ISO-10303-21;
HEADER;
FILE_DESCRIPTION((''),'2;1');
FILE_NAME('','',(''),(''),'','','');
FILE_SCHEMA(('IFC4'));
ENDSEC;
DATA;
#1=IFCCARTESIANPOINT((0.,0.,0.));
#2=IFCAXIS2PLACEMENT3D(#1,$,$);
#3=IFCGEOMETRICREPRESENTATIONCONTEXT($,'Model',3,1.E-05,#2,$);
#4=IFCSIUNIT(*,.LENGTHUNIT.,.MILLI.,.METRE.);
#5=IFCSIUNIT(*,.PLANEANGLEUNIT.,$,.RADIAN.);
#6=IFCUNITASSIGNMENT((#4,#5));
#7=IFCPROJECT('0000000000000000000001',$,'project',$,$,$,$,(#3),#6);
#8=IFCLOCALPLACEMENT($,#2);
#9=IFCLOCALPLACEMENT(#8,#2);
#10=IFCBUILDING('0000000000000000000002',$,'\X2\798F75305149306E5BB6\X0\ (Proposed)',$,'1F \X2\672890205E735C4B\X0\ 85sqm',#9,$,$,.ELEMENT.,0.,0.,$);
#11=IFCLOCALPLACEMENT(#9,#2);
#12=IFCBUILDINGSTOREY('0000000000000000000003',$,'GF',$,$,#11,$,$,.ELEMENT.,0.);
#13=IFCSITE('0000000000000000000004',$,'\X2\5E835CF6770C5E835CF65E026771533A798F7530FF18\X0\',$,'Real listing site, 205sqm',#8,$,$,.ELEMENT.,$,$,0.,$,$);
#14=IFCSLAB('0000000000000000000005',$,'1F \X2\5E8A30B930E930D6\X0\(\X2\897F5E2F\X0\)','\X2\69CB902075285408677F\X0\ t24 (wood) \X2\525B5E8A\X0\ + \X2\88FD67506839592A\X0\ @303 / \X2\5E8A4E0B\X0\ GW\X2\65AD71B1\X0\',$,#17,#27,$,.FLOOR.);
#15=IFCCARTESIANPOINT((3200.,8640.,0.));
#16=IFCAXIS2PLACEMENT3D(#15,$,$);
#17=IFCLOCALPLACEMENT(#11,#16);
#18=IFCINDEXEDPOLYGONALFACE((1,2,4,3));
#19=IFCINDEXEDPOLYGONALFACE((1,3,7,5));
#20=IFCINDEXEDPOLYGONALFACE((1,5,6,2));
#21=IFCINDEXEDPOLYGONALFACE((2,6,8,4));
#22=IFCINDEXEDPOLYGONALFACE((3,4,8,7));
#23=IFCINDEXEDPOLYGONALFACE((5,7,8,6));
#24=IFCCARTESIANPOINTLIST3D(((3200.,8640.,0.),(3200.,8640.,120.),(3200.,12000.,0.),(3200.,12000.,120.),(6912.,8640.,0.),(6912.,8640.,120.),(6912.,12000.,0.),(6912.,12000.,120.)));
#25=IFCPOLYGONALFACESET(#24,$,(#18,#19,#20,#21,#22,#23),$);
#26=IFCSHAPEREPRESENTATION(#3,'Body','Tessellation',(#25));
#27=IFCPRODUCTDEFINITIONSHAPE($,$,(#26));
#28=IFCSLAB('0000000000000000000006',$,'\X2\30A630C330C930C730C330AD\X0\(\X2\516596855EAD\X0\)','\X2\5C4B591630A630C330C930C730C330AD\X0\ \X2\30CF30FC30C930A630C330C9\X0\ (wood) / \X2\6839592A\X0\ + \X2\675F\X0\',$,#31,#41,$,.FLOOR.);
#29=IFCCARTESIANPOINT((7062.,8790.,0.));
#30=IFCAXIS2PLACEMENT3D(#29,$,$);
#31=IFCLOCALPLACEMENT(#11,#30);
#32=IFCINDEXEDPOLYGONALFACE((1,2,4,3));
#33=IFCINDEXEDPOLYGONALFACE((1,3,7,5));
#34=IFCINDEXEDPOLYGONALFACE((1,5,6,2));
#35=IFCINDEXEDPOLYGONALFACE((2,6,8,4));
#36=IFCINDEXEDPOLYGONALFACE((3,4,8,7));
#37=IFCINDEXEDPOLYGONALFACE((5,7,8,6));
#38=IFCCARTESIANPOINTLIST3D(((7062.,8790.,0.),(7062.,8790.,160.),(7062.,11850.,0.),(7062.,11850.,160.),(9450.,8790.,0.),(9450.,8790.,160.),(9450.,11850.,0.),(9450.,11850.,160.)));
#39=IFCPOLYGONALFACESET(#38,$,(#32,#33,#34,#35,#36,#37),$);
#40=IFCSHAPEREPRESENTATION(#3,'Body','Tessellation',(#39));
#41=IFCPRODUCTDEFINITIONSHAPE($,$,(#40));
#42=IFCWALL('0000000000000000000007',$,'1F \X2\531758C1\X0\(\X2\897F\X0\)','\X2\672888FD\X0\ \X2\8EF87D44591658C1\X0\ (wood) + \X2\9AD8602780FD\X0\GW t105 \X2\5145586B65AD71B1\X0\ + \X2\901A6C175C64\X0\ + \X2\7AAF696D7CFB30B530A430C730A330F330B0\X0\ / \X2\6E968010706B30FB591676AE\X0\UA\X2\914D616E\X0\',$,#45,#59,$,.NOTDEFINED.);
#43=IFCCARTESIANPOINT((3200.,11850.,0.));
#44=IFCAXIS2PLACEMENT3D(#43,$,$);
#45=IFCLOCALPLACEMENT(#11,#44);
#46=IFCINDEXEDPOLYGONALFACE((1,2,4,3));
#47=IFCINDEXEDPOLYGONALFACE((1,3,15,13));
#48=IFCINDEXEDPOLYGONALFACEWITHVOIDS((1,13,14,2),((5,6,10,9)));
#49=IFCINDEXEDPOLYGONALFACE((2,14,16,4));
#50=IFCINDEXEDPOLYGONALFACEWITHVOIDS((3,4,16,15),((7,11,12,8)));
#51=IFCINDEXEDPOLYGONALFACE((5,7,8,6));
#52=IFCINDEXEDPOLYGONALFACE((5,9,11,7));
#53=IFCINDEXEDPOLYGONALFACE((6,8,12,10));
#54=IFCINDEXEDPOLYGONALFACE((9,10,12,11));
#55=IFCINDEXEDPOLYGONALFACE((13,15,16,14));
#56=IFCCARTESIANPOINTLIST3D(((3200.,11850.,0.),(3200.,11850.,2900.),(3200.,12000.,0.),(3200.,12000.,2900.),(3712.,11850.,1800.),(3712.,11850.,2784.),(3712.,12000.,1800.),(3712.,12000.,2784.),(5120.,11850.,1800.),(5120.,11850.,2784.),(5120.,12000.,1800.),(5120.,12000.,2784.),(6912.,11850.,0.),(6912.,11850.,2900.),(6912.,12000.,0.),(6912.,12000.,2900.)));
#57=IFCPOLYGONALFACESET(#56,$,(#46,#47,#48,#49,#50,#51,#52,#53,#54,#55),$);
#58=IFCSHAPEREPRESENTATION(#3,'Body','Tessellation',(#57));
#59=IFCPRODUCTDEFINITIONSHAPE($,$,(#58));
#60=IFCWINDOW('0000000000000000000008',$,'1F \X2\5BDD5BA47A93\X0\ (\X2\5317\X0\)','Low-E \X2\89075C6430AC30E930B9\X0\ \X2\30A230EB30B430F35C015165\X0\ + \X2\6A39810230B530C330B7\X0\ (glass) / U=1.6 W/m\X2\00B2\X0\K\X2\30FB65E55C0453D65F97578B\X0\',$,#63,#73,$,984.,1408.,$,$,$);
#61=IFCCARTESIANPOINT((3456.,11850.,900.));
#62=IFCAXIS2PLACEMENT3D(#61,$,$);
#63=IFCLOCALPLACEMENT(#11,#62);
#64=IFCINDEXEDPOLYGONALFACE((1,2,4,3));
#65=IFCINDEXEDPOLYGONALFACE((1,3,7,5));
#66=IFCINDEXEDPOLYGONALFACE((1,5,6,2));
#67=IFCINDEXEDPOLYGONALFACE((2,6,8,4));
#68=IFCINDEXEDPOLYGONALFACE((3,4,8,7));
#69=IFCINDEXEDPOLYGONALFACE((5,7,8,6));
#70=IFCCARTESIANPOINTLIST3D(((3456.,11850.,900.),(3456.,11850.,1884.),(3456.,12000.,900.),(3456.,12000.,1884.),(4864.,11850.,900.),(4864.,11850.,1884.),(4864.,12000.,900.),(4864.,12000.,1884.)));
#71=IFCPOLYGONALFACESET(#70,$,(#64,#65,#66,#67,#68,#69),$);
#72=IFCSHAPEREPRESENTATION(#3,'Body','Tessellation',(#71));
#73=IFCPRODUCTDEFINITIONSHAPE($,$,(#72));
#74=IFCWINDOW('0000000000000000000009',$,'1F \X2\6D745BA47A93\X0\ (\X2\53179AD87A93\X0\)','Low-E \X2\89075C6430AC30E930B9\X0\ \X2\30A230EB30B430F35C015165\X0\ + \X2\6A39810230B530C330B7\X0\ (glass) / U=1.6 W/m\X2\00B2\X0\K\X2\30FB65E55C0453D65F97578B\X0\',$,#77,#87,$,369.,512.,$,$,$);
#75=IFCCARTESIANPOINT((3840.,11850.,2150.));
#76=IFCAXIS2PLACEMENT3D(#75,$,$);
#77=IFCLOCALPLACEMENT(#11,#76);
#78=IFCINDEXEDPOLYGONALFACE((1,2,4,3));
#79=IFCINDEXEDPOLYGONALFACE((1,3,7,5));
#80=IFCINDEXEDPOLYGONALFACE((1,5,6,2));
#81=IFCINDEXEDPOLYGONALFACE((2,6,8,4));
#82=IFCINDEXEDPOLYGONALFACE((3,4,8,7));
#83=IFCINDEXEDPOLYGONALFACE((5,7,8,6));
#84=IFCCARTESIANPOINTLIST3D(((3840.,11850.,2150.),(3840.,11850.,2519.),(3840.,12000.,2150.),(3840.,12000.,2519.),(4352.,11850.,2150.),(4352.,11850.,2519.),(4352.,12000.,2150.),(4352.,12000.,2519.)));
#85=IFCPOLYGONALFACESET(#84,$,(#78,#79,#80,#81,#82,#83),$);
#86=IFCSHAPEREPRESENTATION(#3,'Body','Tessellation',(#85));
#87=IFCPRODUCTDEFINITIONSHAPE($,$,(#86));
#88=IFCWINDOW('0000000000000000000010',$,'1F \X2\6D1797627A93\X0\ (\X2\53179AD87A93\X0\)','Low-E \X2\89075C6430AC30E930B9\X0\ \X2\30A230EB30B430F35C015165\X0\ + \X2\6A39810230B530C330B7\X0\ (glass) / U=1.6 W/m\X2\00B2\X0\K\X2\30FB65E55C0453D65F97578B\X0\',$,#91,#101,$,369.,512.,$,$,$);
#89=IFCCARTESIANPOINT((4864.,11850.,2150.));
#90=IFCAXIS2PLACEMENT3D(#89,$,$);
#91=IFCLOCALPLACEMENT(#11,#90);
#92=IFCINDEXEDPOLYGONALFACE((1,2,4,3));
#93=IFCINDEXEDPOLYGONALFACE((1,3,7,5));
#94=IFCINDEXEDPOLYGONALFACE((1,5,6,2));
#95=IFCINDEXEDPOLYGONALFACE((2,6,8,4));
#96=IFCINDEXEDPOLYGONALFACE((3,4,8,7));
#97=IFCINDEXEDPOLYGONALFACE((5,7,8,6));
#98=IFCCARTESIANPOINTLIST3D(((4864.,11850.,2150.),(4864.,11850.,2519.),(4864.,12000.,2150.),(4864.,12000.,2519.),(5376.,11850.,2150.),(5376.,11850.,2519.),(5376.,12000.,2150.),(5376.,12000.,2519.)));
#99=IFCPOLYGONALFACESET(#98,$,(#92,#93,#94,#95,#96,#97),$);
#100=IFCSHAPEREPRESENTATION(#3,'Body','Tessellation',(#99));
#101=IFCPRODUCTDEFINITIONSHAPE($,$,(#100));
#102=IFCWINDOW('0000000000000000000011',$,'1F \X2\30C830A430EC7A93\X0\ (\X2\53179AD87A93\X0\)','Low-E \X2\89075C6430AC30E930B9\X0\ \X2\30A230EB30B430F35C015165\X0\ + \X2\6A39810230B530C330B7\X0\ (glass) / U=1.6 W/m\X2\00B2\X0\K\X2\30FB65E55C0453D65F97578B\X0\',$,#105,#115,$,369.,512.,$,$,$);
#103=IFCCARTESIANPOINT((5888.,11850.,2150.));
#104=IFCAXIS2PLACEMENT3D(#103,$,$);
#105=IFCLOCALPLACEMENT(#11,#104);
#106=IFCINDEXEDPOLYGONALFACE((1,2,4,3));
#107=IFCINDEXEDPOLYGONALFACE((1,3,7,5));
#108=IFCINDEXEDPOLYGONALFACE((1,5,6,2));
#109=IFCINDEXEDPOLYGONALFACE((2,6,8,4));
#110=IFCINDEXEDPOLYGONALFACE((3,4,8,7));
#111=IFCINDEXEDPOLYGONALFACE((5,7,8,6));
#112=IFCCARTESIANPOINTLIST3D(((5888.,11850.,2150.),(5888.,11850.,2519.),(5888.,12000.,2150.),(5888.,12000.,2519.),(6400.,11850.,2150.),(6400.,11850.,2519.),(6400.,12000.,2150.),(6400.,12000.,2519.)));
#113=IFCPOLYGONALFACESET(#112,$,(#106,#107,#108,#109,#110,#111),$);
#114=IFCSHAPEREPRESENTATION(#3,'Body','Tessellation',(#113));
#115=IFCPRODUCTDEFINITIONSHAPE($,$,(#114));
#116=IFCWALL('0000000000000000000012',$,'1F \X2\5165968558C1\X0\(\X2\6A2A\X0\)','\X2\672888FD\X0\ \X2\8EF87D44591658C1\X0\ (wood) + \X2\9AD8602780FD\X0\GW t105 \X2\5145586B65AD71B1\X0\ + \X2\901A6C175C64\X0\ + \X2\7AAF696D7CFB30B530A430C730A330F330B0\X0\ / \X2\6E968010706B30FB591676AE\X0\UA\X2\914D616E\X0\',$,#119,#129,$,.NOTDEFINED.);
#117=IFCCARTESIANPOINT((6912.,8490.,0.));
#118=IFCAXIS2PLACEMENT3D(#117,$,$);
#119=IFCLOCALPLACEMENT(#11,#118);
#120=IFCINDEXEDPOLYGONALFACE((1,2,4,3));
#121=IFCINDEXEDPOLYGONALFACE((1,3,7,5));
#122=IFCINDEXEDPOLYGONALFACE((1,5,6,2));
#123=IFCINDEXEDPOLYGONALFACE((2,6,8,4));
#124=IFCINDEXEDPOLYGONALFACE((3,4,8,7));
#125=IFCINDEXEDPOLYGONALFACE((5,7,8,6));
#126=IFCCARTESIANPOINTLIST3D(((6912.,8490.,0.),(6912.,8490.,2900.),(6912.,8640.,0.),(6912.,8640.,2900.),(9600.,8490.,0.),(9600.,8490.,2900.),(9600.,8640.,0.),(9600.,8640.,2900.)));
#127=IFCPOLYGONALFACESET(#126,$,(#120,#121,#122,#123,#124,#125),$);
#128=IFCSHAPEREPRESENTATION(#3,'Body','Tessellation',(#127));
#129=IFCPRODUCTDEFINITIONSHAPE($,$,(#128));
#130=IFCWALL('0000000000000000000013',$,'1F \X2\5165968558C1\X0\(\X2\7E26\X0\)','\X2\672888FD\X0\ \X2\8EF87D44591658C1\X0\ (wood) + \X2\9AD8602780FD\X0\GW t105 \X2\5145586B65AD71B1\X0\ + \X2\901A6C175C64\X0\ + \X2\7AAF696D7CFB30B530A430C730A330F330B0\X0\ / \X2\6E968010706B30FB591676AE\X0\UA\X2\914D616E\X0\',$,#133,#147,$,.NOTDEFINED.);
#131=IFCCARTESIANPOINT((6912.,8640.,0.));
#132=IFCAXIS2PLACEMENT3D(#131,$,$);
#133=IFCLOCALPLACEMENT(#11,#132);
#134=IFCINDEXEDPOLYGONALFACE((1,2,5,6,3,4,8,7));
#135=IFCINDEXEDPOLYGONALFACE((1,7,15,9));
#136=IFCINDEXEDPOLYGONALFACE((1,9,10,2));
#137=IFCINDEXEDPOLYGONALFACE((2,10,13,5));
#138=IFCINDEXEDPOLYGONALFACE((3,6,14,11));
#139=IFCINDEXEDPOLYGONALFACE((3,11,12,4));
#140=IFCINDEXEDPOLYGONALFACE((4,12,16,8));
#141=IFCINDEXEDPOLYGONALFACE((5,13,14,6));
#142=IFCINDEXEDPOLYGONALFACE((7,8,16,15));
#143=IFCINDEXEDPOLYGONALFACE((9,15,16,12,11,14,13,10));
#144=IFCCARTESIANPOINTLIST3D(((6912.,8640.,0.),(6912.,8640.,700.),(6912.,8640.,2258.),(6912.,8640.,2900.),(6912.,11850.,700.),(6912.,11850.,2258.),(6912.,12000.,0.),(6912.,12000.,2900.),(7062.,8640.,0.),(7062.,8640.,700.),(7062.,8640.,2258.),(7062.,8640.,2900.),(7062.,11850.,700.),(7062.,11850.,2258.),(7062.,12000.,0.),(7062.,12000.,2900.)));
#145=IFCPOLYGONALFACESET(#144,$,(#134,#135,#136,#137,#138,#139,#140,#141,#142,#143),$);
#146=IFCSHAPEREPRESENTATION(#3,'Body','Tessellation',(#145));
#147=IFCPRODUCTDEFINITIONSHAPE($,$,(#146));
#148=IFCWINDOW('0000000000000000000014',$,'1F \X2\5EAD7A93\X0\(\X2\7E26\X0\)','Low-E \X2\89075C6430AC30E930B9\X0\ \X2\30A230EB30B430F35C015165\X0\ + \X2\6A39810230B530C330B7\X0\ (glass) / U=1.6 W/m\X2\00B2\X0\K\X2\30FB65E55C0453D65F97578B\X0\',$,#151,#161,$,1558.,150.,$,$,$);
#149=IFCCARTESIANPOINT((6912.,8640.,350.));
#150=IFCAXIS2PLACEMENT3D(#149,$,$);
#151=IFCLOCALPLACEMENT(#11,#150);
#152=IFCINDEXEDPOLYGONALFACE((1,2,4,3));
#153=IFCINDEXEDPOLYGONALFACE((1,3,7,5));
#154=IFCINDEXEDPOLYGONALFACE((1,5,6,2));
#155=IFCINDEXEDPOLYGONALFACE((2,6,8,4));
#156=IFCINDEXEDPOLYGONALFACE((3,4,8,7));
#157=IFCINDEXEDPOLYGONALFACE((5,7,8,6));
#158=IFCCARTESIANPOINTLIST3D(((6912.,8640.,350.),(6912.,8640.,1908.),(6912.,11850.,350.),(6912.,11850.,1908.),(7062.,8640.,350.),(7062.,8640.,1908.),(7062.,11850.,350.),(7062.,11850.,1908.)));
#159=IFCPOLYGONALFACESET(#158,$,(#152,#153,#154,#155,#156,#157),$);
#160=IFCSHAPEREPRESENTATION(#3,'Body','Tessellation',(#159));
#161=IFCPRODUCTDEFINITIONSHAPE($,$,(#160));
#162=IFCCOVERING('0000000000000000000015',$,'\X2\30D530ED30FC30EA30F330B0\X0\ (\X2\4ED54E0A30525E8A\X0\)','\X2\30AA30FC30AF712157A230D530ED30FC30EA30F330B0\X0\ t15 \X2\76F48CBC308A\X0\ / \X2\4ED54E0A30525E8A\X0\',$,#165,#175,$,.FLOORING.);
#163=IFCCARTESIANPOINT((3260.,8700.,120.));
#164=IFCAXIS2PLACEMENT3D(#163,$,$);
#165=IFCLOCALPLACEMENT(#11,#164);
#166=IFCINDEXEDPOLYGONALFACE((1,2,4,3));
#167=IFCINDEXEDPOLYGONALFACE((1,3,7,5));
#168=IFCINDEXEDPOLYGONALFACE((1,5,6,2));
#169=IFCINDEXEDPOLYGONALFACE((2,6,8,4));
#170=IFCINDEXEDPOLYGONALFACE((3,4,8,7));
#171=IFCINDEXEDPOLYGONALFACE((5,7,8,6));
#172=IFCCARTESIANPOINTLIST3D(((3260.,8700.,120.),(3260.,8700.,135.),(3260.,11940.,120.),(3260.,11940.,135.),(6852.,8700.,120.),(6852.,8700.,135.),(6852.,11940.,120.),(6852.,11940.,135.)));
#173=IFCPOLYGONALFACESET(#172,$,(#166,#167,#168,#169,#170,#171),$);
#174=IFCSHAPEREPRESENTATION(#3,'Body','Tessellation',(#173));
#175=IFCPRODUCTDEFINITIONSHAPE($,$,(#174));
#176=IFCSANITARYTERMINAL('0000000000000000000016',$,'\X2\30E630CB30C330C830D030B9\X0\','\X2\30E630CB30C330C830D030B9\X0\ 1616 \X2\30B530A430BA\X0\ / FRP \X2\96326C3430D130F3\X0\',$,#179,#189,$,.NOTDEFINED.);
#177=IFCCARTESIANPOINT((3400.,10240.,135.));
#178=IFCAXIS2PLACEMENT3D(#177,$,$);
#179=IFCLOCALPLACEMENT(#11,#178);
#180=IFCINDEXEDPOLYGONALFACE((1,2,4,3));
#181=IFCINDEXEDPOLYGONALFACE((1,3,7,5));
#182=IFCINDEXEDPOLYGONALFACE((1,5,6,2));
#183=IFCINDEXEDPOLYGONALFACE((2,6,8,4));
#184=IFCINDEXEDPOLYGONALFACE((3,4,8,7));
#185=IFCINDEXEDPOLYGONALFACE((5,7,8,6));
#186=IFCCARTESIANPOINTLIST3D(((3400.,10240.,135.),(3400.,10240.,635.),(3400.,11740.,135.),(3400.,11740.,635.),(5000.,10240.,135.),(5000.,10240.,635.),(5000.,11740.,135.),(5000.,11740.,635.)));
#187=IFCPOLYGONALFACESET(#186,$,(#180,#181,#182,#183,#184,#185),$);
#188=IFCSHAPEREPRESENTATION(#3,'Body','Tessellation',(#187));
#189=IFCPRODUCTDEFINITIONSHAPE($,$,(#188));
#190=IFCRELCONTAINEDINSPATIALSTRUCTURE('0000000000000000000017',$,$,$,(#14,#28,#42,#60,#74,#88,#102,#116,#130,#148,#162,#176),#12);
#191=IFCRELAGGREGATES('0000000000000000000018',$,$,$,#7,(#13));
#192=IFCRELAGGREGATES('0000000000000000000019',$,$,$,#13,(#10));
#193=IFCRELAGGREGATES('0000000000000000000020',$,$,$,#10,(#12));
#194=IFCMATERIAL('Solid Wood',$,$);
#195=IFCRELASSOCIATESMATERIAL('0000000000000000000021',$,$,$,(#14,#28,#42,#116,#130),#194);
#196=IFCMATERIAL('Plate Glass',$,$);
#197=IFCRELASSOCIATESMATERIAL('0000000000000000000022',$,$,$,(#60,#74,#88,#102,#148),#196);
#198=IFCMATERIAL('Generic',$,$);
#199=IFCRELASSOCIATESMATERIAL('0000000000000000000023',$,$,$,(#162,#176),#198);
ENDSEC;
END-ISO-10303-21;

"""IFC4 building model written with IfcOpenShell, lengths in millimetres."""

from ifc_helpers import new_model, si_unit, frame, frame_2d, origin, place, context, project, spatial, rectangle, extrude, material, element, fill, save


model = new_model("IFC4")

# Units and contexts
model_context = context("Model", 3, precision=1e-05, world=origin())
ifc_project = project(units=[si_unit("LENGTHUNIT", "METRE", prefix="MILLI"), si_unit("PLANEANGLEUNIT", "RADIAN")], contexts=[model_context])

# Site, building, storey
site_placement = place(None, origin())
site = spatial("IfcSite", under=ifc_project, at=site_placement, Name="広島県広島市東区福田８", ObjectType="Real listing site, 205sqm", CompositionType="ELEMENT", RefElevation=0.0)
building_placement = place(site_placement, origin())
building = spatial("IfcBuilding", under=site, at=building_placement, Name="福田光の家 (Proposed)", ObjectType="1F 木造平屋 85sqm", CompositionType="ELEMENT", ElevationOfRefHeight=0.0, ElevationOfTerrain=0.0)
storey_placement = place(building_placement, origin())
storey = spatial("IfcBuildingStorey", under=building, at=storey_placement, Name="GF", CompositionType="ELEMENT", Elevation=0.0)

# Slabs
ifc_material_1 = material(Name="Solid Wood")
slab_1_placement = place(storey_placement, frame((3200.0, 8640.0, 0.0)))
element("IfcSlab", 1, at=slab_1_placement, inside=storey, material=ifc_material_1, Name="1F 床スラブ(西帯)", Description="構造用合板 t24 (wood) 剛床 + 製材根太 @303 / 床下 GW断熱", PredefinedType="FLOOR", context=model_context, shape_type="SweptSolid", body=[
    extrude(rectangle(XDim=3712.0, YDim=3360.0, at=frame_2d((1856.0, 1680.0))), frame((3200.0, 8640.0, 0.0)), (0.0, 0.0, 1.0), 120.0),
])
slab_2_placement = place(storey_placement, frame((7062.0, 8790.0, 0.0)))
element("IfcSlab", 2, at=slab_2_placement, inside=storey, material=ifc_material_1, Name="ウッドデッキ(入隅庭)", Description="屋外ウッドデッキ ハードウッド (wood) / 根太 + 束", PredefinedType="FLOOR", context=model_context, shape_type="SweptSolid", body=[
    extrude(rectangle(XDim=2388.0, YDim=3060.0, at=frame_2d((1194.0, 1530.0))), frame((7062.0, 8790.0, 0.0)), (0.0, 0.0, 1.0), 160.0),
])

# Wall, openings, windows
wall_1_placement = place(storey_placement, frame((3200.0, 11850.0, 0.0)))
wall_1 = element("IfcWall", 3, at=wall_1_placement, inside=storey, material=ifc_material_1, Name="1F 北壁(西)", Description="木製 軸組外壁 (wood) + 高性能GW t105 充填断熱 + 通気層 + 窯業系サイディング / 準耐火・外皮UA配慮", PredefinedType="NOTDEFINED", context=model_context, shape_type="SweptSolid", body=[
    extrude(rectangle(XDim=3712.0, YDim=150.0, at=frame_2d((1856.0, 75.0))), frame((3200.0, 11850.0, 0.0)), (0.0, 0.0, 1.0), 2900.0),
])
opening_1_placement = place(storey_placement, frame((3456.0, 11850.0, 900.0)))
opening_1 = element("IfcOpeningElement", 4, at=opening_1_placement, cuts=wall_1, PredefinedType="NOTDEFINED", context=model_context, shape_type="SweptSolid", body=[
    extrude(rectangle(XDim=1408.0, YDim=150.0, at=frame_2d((704.0, 75.0))), frame((3456.0, 11850.0, 900.0)), (0.0, 0.0, 1.0), 984.0),
])
opening_2_placement = place(storey_placement, frame((3840.0, 11850.0, 2150.0)))
opening_2 = element("IfcOpeningElement", 5, at=opening_2_placement, cuts=wall_1, PredefinedType="NOTDEFINED", context=model_context, shape_type="SweptSolid", body=[
    extrude(rectangle(XDim=512.0, YDim=150.0, at=frame_2d((256.0, 75.0))), frame((3840.0, 11850.0, 2150.0)), (0.0, 0.0, 1.0), 369.0),
])
opening_3_placement = place(storey_placement, frame((4864.0, 11850.0, 2150.0)))
opening_3 = element("IfcOpeningElement", 6, at=opening_3_placement, cuts=wall_1, PredefinedType="NOTDEFINED", context=model_context, shape_type="SweptSolid", body=[
    extrude(rectangle(XDim=512.0, YDim=150.0, at=frame_2d((256.0, 75.0))), frame((4864.0, 11850.0, 2150.0)), (0.0, 0.0, 1.0), 369.0),
])
opening_4_placement = place(storey_placement, frame((5888.0, 11850.0, 2150.0)))
opening_4 = element("IfcOpeningElement", 7, at=opening_4_placement, cuts=wall_1, PredefinedType="NOTDEFINED", context=model_context, shape_type="SweptSolid", body=[
    extrude(rectangle(XDim=512.0, YDim=150.0, at=frame_2d((256.0, 75.0))), frame((5888.0, 11850.0, 2150.0)), (0.0, 0.0, 1.0), 369.0),
])
ifc_material_2 = material(Name="Plate Glass")
window_1_placement = place(storey_placement, frame((3456.0, 11850.0, 900.0)))
window_1 = element("IfcWindow", 8, at=window_1_placement, inside=storey, material=ifc_material_2, Name="1F 寝室窓 (北)", Description="Low-E 複層ガラス アルゴン封入 + 樹脂サッシ (glass) / U=1.6 W/m²K・日射取得型", OverallHeight=984.0, OverallWidth=1408.0, context=model_context, shape_type="SweptSolid", body=[
    extrude(rectangle(XDim=1408.0, YDim=150.0, at=frame_2d((704.0, 75.0))), frame((3456.0, 11850.0, 900.0)), (0.0, 0.0, 1.0), 984.0),
])
fill(opening_1, window_1)
window_2_placement = place(storey_placement, frame((3840.0, 11850.0, 2150.0)))
window_2 = element("IfcWindow", 9, at=window_2_placement, inside=storey, material=ifc_material_2, Name="1F 浴室窓 (北高窓)", Description="Low-E 複層ガラス アルゴン封入 + 樹脂サッシ (glass) / U=1.6 W/m²K・日射取得型", OverallHeight=369.0, OverallWidth=512.0, context=model_context, shape_type="SweptSolid", body=[
    extrude(rectangle(XDim=512.0, YDim=150.0, at=frame_2d((256.0, 75.0))), frame((3840.0, 11850.0, 2150.0)), (0.0, 0.0, 1.0), 369.0),
])
fill(opening_2, window_2)
window_3_placement = place(storey_placement, frame((4864.0, 11850.0, 2150.0)))
window_3 = element("IfcWindow", 10, at=window_3_placement, inside=storey, material=ifc_material_2, Name="1F 洗面窓 (北高窓)", Description="Low-E 複層ガラス アルゴン封入 + 樹脂サッシ (glass) / U=1.6 W/m²K・日射取得型", OverallHeight=369.0, OverallWidth=512.0, context=model_context, shape_type="SweptSolid", body=[
    extrude(rectangle(XDim=512.0, YDim=150.0, at=frame_2d((256.0, 75.0))), frame((4864.0, 11850.0, 2150.0)), (0.0, 0.0, 1.0), 369.0),
])
fill(opening_3, window_3)
window_4_placement = place(storey_placement, frame((5888.0, 11850.0, 2150.0)))
window_4 = element("IfcWindow", 11, at=window_4_placement, inside=storey, material=ifc_material_2, Name="1F トイレ窓 (北高窓)", Description="Low-E 複層ガラス アルゴン封入 + 樹脂サッシ (glass) / U=1.6 W/m²K・日射取得型", OverallHeight=369.0, OverallWidth=512.0, context=model_context, shape_type="SweptSolid", body=[
    extrude(rectangle(XDim=512.0, YDim=150.0, at=frame_2d((256.0, 75.0))), frame((5888.0, 11850.0, 2150.0)), (0.0, 0.0, 1.0), 369.0),
])
fill(opening_4, window_4)

# Wall
wall_2_placement = place(storey_placement, frame((6912.0, 8490.0, 0.0)))
element("IfcWall", 12, at=wall_2_placement, inside=storey, material=ifc_material_1, Name="1F 入隅壁(横)", Description="木製 軸組外壁 (wood) + 高性能GW t105 充填断熱 + 通気層 + 窯業系サイディング / 準耐火・外皮UA配慮", PredefinedType="NOTDEFINED", context=model_context, shape_type="SweptSolid", body=[
    extrude(rectangle(XDim=2688.0, YDim=150.0, at=frame_2d((1344.0, 75.0))), frame((6912.0, 8490.0, 0.0)), (0.0, 0.0, 1.0), 2900.0),
])

# Wall, opening, window
wall_3_placement = place(storey_placement, frame((6912.0, 8640.0, 0.0)))
wall_3 = element("IfcWall", 13, at=wall_3_placement, inside=storey, material=ifc_material_1, Name="1F 入隅壁(縦)", Description="木製 軸組外壁 (wood) + 高性能GW t105 充填断熱 + 通気層 + 窯業系サイディング / 準耐火・外皮UA配慮", PredefinedType="NOTDEFINED", context=model_context, shape_type="SweptSolid", body=[
    extrude(rectangle(XDim=150.0, YDim=3360.0, at=frame_2d((75.0, 1680.0))), frame((6912.0, 8640.0, 0.0)), (0.0, 0.0, 1.0), 2900.0),
])
opening_5_placement = place(storey_placement, frame((6912.0, 8640.0, 350.0)))
opening_5 = element("IfcOpeningElement", 14, at=opening_5_placement, cuts=wall_3, PredefinedType="NOTDEFINED", context=model_context, shape_type="SweptSolid", body=[
    extrude(rectangle(XDim=150.0, YDim=3210.0, at=frame_2d((75.0, 1605.0))), frame((6912.0, 8640.0, 350.0)), (0.0, 0.0, 1.0), 1558.0),
])
window_5_placement = place(storey_placement, frame((6912.0, 8640.0, 350.0)))
window_5 = element("IfcWindow", 15, at=window_5_placement, inside=storey, material=ifc_material_2, Name="1F 庭窓(縦)", Description="Low-E 複層ガラス アルゴン封入 + 樹脂サッシ (glass) / U=1.6 W/m²K・日射取得型", OverallHeight=1558.0, OverallWidth=150.0, context=model_context, shape_type="SweptSolid", body=[
    extrude(rectangle(XDim=150.0, YDim=3210.0, at=frame_2d((75.0, 1605.0))), frame((6912.0, 8640.0, 350.0)), (0.0, 0.0, 1.0), 1558.0),
])
fill(opening_5, window_5)

# Covering
ifc_material_3 = material(Name="Generic")
covering_placement = place(storey_placement, frame((3260.0, 8700.0, 120.0)))
element("IfcCovering", 16, at=covering_placement, inside=storey, material=ifc_material_3, Name="フローリング (仕上げ床)", Description="オーク無垢フローリング t15 直貼り / 仕上げ床", PredefinedType="FLOORING", context=model_context, shape_type="SweptSolid", body=[
    extrude(rectangle(XDim=3592.0, YDim=3240.0, at=frame_2d((1796.0, 1620.0))), frame((3260.0, 8700.0, 120.0)), (0.0, 0.0, 1.0), 15.0),
])

# Sanitary terminal
sanitary_terminal_1_placement = place(storey_placement, frame((3400.0, 10240.0, 135.0)))
element("IfcSanitaryTerminal", 17, at=sanitary_terminal_1_placement, inside=storey, material=ifc_material_3, Name="ユニットバス", Description="ユニットバス 1616 サイズ / FRP 防水パン", PredefinedType="NOTDEFINED", context=model_context, shape_type="SweptSolid", body=[
    extrude(rectangle(XDim=1600.0, YDim=1500.0, at=frame_2d((800.0, 750.0))), frame((3400.0, 10240.0, 135.0)), (0.0, 0.0, 1.0), 500.0),
])

save(model, "model.ifc")
